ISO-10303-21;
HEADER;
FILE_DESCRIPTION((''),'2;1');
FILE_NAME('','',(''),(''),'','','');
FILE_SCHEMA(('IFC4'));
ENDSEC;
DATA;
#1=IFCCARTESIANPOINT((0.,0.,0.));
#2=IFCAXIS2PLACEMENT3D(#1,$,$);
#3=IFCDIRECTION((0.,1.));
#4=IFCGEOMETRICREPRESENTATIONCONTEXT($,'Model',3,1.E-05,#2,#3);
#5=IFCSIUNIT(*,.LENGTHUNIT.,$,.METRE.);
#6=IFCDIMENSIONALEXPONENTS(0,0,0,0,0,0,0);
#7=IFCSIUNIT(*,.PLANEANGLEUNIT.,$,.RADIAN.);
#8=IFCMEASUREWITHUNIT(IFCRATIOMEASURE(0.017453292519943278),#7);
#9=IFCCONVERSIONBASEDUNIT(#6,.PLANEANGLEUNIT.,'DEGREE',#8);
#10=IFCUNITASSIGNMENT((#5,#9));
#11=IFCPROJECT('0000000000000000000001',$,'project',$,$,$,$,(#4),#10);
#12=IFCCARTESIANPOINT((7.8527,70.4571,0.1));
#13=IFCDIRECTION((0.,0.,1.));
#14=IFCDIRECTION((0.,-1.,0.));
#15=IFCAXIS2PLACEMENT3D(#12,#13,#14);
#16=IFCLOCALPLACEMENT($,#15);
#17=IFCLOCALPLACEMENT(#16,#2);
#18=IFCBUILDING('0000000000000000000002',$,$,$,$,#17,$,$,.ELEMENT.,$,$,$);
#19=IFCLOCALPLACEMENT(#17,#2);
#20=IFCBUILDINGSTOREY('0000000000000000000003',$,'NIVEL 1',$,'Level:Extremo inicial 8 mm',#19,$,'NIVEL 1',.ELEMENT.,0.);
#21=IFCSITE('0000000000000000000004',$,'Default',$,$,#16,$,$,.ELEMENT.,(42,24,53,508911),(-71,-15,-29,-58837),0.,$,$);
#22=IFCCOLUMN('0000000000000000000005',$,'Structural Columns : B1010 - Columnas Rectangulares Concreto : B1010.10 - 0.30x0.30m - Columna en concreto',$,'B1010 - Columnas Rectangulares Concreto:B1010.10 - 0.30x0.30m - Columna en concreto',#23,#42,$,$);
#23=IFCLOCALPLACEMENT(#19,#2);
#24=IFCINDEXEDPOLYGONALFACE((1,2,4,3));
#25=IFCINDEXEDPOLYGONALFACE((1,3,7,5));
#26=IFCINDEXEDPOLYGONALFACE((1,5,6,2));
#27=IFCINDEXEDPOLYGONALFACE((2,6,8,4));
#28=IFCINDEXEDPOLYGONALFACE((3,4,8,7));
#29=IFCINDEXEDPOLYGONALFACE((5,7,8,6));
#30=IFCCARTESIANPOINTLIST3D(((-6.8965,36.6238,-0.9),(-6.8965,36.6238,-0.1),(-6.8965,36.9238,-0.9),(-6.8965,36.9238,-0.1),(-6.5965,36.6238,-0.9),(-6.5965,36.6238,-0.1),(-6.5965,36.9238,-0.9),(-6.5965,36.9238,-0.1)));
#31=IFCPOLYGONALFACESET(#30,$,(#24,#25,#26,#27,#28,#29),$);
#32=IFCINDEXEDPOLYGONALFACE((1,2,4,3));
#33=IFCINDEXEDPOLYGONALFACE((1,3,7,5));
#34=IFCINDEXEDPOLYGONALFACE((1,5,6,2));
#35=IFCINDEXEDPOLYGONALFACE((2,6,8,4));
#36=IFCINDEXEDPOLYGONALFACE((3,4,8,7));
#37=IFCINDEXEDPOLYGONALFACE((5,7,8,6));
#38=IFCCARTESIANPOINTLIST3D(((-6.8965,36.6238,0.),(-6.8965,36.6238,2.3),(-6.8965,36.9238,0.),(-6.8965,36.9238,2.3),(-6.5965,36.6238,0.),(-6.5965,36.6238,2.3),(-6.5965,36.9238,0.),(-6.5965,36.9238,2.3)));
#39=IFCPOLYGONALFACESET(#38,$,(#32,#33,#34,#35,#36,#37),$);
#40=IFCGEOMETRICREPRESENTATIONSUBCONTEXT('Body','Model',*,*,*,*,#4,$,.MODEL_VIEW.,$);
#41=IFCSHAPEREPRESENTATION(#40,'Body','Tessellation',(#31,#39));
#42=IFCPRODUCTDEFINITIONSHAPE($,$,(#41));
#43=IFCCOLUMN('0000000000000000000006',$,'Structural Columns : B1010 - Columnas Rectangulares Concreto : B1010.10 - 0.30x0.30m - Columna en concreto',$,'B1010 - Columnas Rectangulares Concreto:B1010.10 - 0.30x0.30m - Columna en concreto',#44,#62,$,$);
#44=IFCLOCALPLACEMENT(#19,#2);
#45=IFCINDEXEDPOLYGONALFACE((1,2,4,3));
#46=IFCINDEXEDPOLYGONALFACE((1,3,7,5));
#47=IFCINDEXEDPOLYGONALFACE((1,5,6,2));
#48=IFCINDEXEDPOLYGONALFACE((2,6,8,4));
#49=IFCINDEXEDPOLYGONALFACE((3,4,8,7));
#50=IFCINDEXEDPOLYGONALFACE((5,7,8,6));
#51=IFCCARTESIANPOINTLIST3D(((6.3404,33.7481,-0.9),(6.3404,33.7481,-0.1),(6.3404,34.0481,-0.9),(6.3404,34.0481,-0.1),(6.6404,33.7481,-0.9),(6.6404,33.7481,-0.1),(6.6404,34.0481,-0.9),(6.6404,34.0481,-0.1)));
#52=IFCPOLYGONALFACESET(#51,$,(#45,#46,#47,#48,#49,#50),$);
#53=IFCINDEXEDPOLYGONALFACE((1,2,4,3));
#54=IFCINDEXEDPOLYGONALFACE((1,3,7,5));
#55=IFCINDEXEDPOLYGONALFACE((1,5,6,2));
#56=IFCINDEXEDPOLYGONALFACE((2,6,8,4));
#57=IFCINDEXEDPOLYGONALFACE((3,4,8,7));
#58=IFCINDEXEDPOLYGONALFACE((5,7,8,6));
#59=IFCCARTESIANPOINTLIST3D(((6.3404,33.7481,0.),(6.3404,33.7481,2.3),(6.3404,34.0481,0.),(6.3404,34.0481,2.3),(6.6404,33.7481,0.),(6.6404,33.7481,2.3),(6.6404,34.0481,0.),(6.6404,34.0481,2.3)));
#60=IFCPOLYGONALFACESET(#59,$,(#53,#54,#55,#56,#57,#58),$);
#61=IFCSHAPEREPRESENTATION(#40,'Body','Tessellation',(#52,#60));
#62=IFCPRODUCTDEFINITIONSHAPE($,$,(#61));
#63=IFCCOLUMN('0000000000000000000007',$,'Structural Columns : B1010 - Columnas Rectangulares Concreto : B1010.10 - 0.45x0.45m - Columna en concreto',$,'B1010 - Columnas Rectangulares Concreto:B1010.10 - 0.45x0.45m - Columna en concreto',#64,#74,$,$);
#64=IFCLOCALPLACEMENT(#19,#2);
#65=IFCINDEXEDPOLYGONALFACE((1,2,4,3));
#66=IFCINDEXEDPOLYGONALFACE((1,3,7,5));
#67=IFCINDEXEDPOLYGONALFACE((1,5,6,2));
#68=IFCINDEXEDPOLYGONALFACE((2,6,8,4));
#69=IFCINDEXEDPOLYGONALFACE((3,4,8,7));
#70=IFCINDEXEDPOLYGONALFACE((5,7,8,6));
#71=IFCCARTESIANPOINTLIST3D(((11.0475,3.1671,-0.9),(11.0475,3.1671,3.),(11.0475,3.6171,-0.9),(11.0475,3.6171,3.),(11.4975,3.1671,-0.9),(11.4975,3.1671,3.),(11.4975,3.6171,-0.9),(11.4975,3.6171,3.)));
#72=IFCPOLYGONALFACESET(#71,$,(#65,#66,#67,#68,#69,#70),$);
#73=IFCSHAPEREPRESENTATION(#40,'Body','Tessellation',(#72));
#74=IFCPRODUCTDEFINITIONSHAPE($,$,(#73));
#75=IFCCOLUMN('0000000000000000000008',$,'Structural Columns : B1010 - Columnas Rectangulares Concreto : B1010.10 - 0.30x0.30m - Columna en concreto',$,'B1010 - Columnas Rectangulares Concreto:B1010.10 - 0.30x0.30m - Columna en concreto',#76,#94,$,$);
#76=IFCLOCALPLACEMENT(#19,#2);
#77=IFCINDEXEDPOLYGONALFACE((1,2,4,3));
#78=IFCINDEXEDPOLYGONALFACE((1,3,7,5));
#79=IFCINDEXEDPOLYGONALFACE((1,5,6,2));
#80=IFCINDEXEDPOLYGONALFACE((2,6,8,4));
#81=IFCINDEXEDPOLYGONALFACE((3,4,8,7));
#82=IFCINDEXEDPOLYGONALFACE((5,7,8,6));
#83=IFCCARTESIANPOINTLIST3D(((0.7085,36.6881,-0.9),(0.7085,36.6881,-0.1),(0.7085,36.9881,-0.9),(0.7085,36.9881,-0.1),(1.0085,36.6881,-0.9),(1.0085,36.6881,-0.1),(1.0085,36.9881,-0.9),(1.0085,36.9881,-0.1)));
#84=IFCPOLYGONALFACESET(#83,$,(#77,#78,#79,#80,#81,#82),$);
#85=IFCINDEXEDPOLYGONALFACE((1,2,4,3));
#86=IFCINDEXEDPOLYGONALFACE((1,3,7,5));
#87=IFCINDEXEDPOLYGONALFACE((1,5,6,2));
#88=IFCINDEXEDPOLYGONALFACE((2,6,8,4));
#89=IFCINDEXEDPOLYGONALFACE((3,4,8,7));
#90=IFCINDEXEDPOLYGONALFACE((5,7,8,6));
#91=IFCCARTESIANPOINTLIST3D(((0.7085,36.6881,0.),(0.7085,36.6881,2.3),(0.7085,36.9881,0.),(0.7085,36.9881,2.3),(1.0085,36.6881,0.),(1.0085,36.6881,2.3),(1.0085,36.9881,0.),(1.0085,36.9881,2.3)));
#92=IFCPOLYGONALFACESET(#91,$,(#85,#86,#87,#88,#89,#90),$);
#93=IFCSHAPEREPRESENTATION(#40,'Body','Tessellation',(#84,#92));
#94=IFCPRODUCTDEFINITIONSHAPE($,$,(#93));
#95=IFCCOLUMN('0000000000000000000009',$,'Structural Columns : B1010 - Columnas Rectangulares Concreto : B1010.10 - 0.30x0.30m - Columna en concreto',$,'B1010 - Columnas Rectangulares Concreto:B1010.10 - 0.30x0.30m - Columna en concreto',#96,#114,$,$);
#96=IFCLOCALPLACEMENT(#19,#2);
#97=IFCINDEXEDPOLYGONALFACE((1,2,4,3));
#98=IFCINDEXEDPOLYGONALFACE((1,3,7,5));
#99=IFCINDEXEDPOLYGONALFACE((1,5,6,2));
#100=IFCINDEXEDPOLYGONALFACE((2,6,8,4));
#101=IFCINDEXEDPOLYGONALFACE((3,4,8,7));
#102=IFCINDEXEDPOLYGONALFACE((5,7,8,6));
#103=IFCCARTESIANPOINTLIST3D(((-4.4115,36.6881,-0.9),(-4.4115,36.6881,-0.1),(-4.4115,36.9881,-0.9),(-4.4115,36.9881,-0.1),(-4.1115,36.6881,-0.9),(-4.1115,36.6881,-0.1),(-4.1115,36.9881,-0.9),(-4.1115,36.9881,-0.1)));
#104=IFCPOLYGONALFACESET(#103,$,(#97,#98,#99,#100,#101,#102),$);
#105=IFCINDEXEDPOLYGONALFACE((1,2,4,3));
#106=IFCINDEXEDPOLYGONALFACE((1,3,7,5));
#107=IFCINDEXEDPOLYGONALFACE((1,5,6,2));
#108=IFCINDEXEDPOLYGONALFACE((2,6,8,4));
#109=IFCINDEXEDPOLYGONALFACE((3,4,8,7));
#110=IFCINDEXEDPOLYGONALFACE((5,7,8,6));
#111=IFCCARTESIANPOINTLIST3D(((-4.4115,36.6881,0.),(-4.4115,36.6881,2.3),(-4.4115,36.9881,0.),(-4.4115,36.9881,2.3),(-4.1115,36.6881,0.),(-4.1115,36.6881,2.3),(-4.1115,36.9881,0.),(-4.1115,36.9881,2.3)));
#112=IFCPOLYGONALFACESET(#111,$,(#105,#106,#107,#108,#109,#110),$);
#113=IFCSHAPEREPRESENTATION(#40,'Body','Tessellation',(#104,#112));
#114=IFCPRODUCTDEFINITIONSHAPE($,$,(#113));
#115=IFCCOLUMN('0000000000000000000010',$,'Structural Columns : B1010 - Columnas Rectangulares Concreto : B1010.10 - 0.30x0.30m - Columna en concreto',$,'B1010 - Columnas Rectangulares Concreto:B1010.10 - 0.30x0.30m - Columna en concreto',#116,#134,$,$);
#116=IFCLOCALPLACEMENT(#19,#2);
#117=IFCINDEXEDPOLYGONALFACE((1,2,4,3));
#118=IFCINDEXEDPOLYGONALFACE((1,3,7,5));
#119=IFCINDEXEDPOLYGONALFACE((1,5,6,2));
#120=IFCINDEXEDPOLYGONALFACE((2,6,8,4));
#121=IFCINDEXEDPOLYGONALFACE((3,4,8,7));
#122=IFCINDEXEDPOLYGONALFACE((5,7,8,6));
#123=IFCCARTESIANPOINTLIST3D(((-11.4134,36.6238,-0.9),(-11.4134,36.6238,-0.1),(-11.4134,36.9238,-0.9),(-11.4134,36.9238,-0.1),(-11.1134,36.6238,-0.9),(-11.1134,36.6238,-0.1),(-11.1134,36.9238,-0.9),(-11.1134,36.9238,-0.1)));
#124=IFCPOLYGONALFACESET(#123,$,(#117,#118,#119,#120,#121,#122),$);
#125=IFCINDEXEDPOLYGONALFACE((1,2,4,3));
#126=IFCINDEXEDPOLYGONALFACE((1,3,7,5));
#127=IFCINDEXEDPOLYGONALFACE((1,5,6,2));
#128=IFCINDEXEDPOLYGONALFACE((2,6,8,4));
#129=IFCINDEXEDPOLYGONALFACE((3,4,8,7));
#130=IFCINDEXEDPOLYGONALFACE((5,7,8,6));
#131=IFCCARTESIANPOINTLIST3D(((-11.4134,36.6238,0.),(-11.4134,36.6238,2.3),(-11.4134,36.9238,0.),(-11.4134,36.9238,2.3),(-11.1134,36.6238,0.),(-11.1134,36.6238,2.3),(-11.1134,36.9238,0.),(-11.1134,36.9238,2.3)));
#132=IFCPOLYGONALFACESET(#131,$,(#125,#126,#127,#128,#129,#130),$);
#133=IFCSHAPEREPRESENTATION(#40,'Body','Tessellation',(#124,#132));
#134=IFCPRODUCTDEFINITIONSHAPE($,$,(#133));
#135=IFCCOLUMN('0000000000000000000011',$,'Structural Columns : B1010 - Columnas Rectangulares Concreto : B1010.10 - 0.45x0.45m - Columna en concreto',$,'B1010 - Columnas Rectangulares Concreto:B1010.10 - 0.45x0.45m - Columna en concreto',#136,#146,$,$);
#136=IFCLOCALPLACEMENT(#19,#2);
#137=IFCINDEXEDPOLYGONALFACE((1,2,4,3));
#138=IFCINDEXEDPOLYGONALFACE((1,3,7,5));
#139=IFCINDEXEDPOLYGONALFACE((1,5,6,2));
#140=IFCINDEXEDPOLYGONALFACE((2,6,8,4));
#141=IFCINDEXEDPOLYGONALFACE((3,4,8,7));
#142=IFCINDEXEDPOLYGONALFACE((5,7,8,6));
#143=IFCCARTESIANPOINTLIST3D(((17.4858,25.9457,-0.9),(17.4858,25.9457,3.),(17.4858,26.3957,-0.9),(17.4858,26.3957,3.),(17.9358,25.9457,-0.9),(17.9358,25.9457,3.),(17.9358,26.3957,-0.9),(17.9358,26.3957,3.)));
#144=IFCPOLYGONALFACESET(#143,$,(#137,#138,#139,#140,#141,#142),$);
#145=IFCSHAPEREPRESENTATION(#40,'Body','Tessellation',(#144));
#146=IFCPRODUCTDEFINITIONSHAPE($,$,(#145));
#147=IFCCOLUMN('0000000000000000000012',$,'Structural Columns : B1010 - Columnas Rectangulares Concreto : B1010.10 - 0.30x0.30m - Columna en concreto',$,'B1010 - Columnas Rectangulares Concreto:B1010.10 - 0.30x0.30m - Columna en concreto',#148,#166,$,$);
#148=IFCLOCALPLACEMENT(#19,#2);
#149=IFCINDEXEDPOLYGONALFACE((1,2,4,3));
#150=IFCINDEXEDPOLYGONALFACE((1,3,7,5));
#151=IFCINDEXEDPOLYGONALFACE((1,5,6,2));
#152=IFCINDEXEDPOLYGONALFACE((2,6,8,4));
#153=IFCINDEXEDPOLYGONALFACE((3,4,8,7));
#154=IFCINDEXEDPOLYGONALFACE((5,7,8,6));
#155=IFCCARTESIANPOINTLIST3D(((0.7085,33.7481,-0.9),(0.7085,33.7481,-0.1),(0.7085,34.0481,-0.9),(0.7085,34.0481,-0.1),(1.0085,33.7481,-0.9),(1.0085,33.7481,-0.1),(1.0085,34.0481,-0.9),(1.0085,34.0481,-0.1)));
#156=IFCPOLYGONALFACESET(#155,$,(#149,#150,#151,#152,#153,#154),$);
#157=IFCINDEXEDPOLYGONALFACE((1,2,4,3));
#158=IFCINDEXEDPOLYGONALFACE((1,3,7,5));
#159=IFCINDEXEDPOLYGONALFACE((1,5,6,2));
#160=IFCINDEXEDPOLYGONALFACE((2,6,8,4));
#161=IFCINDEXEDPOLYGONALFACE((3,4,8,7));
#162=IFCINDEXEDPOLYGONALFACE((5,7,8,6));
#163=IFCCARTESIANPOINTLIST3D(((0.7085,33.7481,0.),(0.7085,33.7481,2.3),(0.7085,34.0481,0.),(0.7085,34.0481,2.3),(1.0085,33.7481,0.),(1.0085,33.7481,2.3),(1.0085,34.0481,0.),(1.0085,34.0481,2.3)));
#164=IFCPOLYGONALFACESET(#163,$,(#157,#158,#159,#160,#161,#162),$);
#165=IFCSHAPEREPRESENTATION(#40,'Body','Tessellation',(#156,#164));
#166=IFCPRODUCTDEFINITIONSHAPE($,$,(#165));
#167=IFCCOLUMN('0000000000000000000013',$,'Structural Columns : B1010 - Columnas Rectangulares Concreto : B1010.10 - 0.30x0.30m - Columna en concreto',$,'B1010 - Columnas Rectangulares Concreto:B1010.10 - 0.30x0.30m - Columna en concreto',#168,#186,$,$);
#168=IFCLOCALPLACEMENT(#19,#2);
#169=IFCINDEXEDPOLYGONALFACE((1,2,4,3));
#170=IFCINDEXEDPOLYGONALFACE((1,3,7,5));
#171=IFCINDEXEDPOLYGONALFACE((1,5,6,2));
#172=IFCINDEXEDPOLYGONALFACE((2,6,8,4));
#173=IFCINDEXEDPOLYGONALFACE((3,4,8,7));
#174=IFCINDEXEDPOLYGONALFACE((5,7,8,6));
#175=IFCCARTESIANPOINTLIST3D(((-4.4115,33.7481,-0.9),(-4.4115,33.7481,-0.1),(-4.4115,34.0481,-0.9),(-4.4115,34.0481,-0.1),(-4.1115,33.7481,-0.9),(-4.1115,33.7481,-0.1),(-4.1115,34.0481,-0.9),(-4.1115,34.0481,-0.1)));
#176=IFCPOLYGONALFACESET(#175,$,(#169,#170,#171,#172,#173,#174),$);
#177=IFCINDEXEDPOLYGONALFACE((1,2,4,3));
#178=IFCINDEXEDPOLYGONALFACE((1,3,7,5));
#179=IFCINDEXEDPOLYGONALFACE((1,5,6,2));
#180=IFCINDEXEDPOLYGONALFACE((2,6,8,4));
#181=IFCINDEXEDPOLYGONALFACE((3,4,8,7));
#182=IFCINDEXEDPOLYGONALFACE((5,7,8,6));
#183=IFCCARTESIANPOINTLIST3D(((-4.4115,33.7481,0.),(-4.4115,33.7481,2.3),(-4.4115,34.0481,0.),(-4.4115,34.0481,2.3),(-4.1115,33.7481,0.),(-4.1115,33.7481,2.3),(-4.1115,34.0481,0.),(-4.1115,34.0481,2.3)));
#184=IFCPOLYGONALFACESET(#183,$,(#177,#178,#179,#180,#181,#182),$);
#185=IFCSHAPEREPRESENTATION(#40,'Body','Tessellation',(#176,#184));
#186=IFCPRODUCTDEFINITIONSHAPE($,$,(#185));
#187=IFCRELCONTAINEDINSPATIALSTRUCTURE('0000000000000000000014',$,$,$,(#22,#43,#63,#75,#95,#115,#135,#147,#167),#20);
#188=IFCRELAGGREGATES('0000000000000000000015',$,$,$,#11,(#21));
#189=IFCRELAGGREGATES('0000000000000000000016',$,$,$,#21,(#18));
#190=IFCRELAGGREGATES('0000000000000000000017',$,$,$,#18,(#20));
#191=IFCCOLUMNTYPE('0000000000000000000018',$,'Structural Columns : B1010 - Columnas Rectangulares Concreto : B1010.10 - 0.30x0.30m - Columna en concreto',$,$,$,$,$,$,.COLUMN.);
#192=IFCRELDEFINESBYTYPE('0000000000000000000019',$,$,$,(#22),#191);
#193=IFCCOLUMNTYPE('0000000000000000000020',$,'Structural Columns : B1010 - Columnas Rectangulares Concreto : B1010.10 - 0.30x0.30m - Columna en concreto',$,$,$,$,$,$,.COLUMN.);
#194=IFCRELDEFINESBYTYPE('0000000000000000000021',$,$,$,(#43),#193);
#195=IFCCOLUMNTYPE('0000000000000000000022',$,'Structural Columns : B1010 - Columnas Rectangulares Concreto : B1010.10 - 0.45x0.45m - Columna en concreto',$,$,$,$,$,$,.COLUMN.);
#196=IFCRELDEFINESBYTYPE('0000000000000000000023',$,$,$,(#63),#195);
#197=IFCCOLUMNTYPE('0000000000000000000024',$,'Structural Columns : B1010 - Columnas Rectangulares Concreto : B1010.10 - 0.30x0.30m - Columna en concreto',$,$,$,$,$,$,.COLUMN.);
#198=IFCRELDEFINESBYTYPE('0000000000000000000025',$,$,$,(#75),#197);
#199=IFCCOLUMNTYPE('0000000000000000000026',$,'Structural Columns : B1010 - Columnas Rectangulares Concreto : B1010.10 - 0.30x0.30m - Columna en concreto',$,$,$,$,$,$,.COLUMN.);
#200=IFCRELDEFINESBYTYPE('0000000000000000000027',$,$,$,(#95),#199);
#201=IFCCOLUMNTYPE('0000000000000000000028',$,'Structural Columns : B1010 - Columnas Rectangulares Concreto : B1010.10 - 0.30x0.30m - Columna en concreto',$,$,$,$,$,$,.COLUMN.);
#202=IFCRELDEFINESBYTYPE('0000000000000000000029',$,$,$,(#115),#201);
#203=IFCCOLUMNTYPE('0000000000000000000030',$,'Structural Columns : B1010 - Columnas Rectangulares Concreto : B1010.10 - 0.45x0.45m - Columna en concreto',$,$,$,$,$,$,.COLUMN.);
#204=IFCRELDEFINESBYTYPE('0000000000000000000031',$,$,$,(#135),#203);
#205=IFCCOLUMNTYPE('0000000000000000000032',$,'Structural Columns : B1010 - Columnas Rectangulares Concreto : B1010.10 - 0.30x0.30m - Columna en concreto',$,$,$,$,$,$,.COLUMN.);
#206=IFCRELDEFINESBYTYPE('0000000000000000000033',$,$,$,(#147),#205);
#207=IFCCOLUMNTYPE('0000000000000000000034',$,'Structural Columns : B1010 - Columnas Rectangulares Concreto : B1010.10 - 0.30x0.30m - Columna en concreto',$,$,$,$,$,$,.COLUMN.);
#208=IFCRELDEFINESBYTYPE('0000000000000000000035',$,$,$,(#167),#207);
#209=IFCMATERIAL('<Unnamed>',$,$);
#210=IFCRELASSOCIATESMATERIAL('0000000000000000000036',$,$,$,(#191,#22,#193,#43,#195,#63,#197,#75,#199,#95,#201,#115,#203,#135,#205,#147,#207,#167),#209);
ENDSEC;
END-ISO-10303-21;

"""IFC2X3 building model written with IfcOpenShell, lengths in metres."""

from ifc_helpers import new_model, entity, si_unit, converted_unit, direction, frame, frame_2d, origin, origin_2d_with_axis, place, context, subcontext, project, spatial, rectangle, extrude, source, transform, mapped, material, type_object, type_shapes, element, save


model = new_model("IFC2X3")

# Units and contexts
model_context = context("Model", 3, precision=1e-05, world=origin(), true_north=direction((0.0, 1.0)))
body_context = subcontext(model_context, "Body", "Model", "MODEL_VIEW")
ifc_project = project(units=[si_unit("LENGTHUNIT", "METRE"), converted_unit("PLANEANGLEUNIT", "DEGREE", entity("IfcRatioMeasure", 0.017453292519943278), si_unit("PLANEANGLEUNIT", "RADIAN"), dimensions=[0, 0, 0, 0, 0, 0, 0])], contexts=[model_context])

# Site, building, storey
site_placement = place(None, frame((7.8527, 70.4571, 0.1), z_axis=(0.0, 0.0, 1.0), x_axis=(0.0, -1.0, 0.0)))
site = spatial("IfcSite", under=ifc_project, at=site_placement, Name="Default", CompositionType="ELEMENT", RefLatitude=(42, 24, 53, 508911), RefLongitude=(-71, -15, -29, -58837), RefElevation=0.0)
building_placement = place(site_placement, origin())
building = spatial("IfcBuilding", under=site, at=building_placement, CompositionType="ELEMENT")
storey_placement = place(building_placement, origin())
storey = spatial("IfcBuildingStorey", under=building, at=storey_placement, Name="NIVEL 1", ObjectType="Level:Extremo inicial 8 mm", LongName="NIVEL 1", CompositionType="ELEMENT", Elevation=0.0)

# Columns
ifc_material_1 = material(Name="<Unnamed>")
column_type_1 = type_object("IfcColumnType", Name="Structural Columns : B1010 - Columnas Rectangulares Concreto : B1010.10 - 0.30x0.30m - Columna en concreto", PredefinedType="COLUMN", material=ifc_material_1)
shared_shape_1 = source(origin(), body_context, "Body", "SweptSolid", [
    extrude(rectangle(XDim=0.3, YDim=0.3, at=frame_2d((0.0, 0.0), x_axis=(1.0, 0.0))), frame((-6.7465, 36.7738, -0.9), z_axis=(0.0, 0.0, 1.0), x_axis=(0.0, -1.0, 0.0)), (0.0, 0.0, 1.0), 0.8),
    extrude(rectangle(XDim=0.3, YDim=0.3, at=frame_2d((0.0, 0.0), x_axis=(1.0, 0.0))), frame((-6.7465, 36.7738, 0.0), z_axis=(0.0, 0.0, 1.0), x_axis=(0.0, -1.0, 0.0)), (0.0, 0.0, 1.0), 2.3),
])
type_shapes(column_type_1, [shared_shape_1])
column_1_placement = place(storey_placement, origin())
element("IfcColumn", 1, at=column_1_placement, inside=storey, type_object=column_type_1, material=ifc_material_1, Name="Structural Columns : B1010 - Columnas Rectangulares Concreto : B1010.10 - 0.30x0.30m - Columna en concreto", ObjectType="B1010 - Columnas Rectangulares Concreto:B1010.10 - 0.30x0.30m - Columna en concreto", context=body_context, shape_type="MappedRepresentation", body=[
    mapped(shared_shape_1, transform((0.0, 0.0, 0.0), scale=1.0)),
])
column_type_2 = type_object("IfcColumnType", Name="Structural Columns : B1010 - Columnas Rectangulares Concreto : B1010.10 - 0.30x0.30m - Columna en concreto", PredefinedType="COLUMN", material=ifc_material_1)
shared_shape_2 = source(origin(), body_context, "Body", "SweptSolid", [
    extrude(rectangle(XDim=0.3, YDim=0.3, at=frame_2d((0.0, 0.0), x_axis=(1.0, 0.0))), frame((6.4904, 33.8981, -0.9), z_axis=(0.0, 0.0, 1.0), x_axis=(0.0, -1.0, 0.0)), (0.0, 0.0, 1.0), 0.8),
    extrude(rectangle(XDim=0.3, YDim=0.3, at=frame_2d((0.0, 0.0), x_axis=(1.0, 0.0))), frame((6.4904, 33.8981, 0.0), z_axis=(0.0, 0.0, 1.0), x_axis=(0.0, -1.0, 0.0)), (0.0, 0.0, 1.0), 2.3),
])
type_shapes(column_type_2, [shared_shape_2])
column_2_placement = place(storey_placement, origin())
element("IfcColumn", 2, at=column_2_placement, inside=storey, type_object=column_type_2, material=ifc_material_1, Name="Structural Columns : B1010 - Columnas Rectangulares Concreto : B1010.10 - 0.30x0.30m - Columna en concreto", ObjectType="B1010 - Columnas Rectangulares Concreto:B1010.10 - 0.30x0.30m - Columna en concreto", context=body_context, shape_type="MappedRepresentation", body=[
    mapped(shared_shape_2, transform((0.0, 0.0, 0.0), scale=1.0)),
])
column_type_3 = type_object("IfcColumnType", Name="Structural Columns : B1010 - Columnas Rectangulares Concreto : B1010.10 - 0.45x0.45m - Columna en concreto", PredefinedType="COLUMN", material=ifc_material_1)
shared_shape_3 = source(origin(), body_context, "Body", "SweptSolid", [
    extrude(rectangle(XDim=0.45, YDim=0.45, at=frame_2d((0.0, 0.0), x_axis=(1.0, 0.0))), frame((11.2725, 3.3921, -0.9), z_axis=(0.0, 0.0, 1.0), x_axis=(0.0, -1.0, 0.0)), (0.0, 0.0, 1.0), 3.9),
])
type_shapes(column_type_3, [shared_shape_3])
column_3_placement = place(storey_placement, origin())
element("IfcColumn", 3, at=column_3_placement, inside=storey, type_object=column_type_3, material=ifc_material_1, Name="Structural Columns : B1010 - Columnas Rectangulares Concreto : B1010.10 - 0.45x0.45m - Columna en concreto", ObjectType="B1010 - Columnas Rectangulares Concreto:B1010.10 - 0.45x0.45m - Columna en concreto", context=body_context, shape_type="MappedRepresentation", body=[
    mapped(shared_shape_3, transform((0.0, 0.0, 0.0), scale=1.0)),
])
column_type_4 = type_object("IfcColumnType", Name="Structural Columns : B1010 - Columnas Rectangulares Concreto : B1010.10 - 0.30x0.30m - Columna en concreto", PredefinedType="COLUMN", material=ifc_material_1)
shared_shape_4 = source(origin(), body_context, "Body", "SweptSolid", [
    extrude(rectangle(XDim=0.3, YDim=0.3, at=origin_2d_with_axis()), frame((0.8585, 36.8381, -0.9), z_axis=(0.0, 0.0, 1.0), x_axis=(0.0, -1.0, 0.0)), (0.0, 0.0, 1.0), 0.8),
    extrude(rectangle(XDim=0.3, YDim=0.3, at=origin_2d_with_axis()), frame((0.8585, 36.8381, 0.0), z_axis=(0.0, 0.0, 1.0), x_axis=(0.0, -1.0, 0.0)), (0.0, 0.0, 1.0), 2.3),
])
type_shapes(column_type_4, [shared_shape_4])
column_4_placement = place(storey_placement, origin())
element("IfcColumn", 4, at=column_4_placement, inside=storey, type_object=column_type_4, material=ifc_material_1, Name="Structural Columns : B1010 - Columnas Rectangulares Concreto : B1010.10 - 0.30x0.30m - Columna en concreto", ObjectType="B1010 - Columnas Rectangulares Concreto:B1010.10 - 0.30x0.30m - Columna en concreto", context=body_context, shape_type="MappedRepresentation", body=[
    mapped(shared_shape_4, transform((0.0, 0.0, 0.0), scale=1.0)),
])
column_type_5 = type_object("IfcColumnType", Name="Structural Columns : B1010 - Columnas Rectangulares Concreto : B1010.10 - 0.30x0.30m - Columna en concreto", PredefinedType="COLUMN", material=ifc_material_1)
shared_shape_5 = source(origin(), body_context, "Body", "SweptSolid", [
    extrude(rectangle(XDim=0.3, YDim=0.3, at=origin_2d_with_axis()), frame((-4.2615, 36.8381, -0.9), z_axis=(0.0, 0.0, 1.0), x_axis=(0.0, -1.0, 0.0)), (0.0, 0.0, 1.0), 0.8),
    extrude(rectangle(XDim=0.3, YDim=0.3, at=origin_2d_with_axis()), frame((-4.2615, 36.8381, 0.0), z_axis=(0.0, 0.0, 1.0), x_axis=(0.0, -1.0, 0.0)), (0.0, 0.0, 1.0), 2.3),
])
type_shapes(column_type_5, [shared_shape_5])
column_5_placement = place(storey_placement, origin())
element("IfcColumn", 5, at=column_5_placement, inside=storey, type_object=column_type_5, material=ifc_material_1, Name="Structural Columns : B1010 - Columnas Rectangulares Concreto : B1010.10 - 0.30x0.30m - Columna en concreto", ObjectType="B1010 - Columnas Rectangulares Concreto:B1010.10 - 0.30x0.30m - Columna en concreto", context=body_context, shape_type="MappedRepresentation", body=[
    mapped(shared_shape_5, transform((0.0, 0.0, 0.0), scale=1.0)),
])
column_type_6 = type_object("IfcColumnType", Name="Structural Columns : B1010 - Columnas Rectangulares Concreto : B1010.10 - 0.30x0.30m - Columna en concreto", PredefinedType="COLUMN", material=ifc_material_1)
shared_shape_6 = source(origin(), body_context, "Body", "SweptSolid", [
    extrude(rectangle(XDim=0.3, YDim=0.3, at=origin_2d_with_axis()), frame((-11.2634, 36.7738, -0.9), z_axis=(0.0, 0.0, 1.0), x_axis=(0.0, -1.0, 0.0)), (0.0, 0.0, 1.0), 0.8),
    extrude(rectangle(XDim=0.3, YDim=0.3, at=origin_2d_with_axis()), frame((-11.2634, 36.7738, 0.0), z_axis=(0.0, 0.0, 1.0), x_axis=(0.0, -1.0, 0.0)), (0.0, 0.0, 1.0), 2.3),
])
type_shapes(column_type_6, [shared_shape_6])
column_6_placement = place(storey_placement, origin())
element("IfcColumn", 6, at=column_6_placement, inside=storey, type_object=column_type_6, material=ifc_material_1, Name="Structural Columns : B1010 - Columnas Rectangulares Concreto : B1010.10 - 0.30x0.30m - Columna en concreto", ObjectType="B1010 - Columnas Rectangulares Concreto:B1010.10 - 0.30x0.30m - Columna en concreto", context=body_context, shape_type="MappedRepresentation", body=[
    mapped(shared_shape_6, transform((0.0, 0.0, 0.0), scale=1.0)),
])
column_type_7 = type_object("IfcColumnType", Name="Structural Columns : B1010 - Columnas Rectangulares Concreto : B1010.10 - 0.45x0.45m - Columna en concreto", PredefinedType="COLUMN", material=ifc_material_1)
shared_shape_7 = source(origin(), body_context, "Body", "SweptSolid", [
    extrude(rectangle(XDim=0.45, YDim=0.45, at=origin_2d_with_axis()), frame((17.7108, 26.1707, -0.9), z_axis=(0.0, 0.0, 1.0), x_axis=(0.0, -1.0, 0.0)), (0.0, 0.0, 1.0), 3.9),
])
type_shapes(column_type_7, [shared_shape_7])
column_7_placement = place(storey_placement, origin())
element("IfcColumn", 7, at=column_7_placement, inside=storey, type_object=column_type_7, material=ifc_material_1, Name="Structural Columns : B1010 - Columnas Rectangulares Concreto : B1010.10 - 0.45x0.45m - Columna en concreto", ObjectType="B1010 - Columnas Rectangulares Concreto:B1010.10 - 0.45x0.45m - Columna en concreto", context=body_context, shape_type="MappedRepresentation", body=[
    mapped(shared_shape_7, transform((0.0, 0.0, 0.0), scale=1.0)),
])
column_type_8 = type_object("IfcColumnType", Name="Structural Columns : B1010 - Columnas Rectangulares Concreto : B1010.10 - 0.30x0.30m - Columna en concreto", PredefinedType="COLUMN", material=ifc_material_1)
shared_shape_8 = source(origin(), body_context, "Body", "SweptSolid", [
    extrude(rectangle(XDim=0.3, YDim=0.3, at=origin_2d_with_axis()), frame((0.8585, 33.8981, -0.9), z_axis=(0.0, 0.0, 1.0), x_axis=(0.0, -1.0, 0.0)), (0.0, 0.0, 1.0), 0.8),
    extrude(rectangle(XDim=0.3, YDim=0.3, at=origin_2d_with_axis()), frame((0.8585, 33.8981, 0.0), z_axis=(0.0, 0.0, 1.0), x_axis=(0.0, -1.0, 0.0)), (0.0, 0.0, 1.0), 2.3),
])
type_shapes(column_type_8, [shared_shape_8])
column_8_placement = place(storey_placement, origin())
element("IfcColumn", 8, at=column_8_placement, inside=storey, type_object=column_type_8, material=ifc_material_1, Name="Structural Columns : B1010 - Columnas Rectangulares Concreto : B1010.10 - 0.30x0.30m - Columna en concreto", ObjectType="B1010 - Columnas Rectangulares Concreto:B1010.10 - 0.30x0.30m - Columna en concreto", context=body_context, shape_type="MappedRepresentation", body=[
    mapped(shared_shape_8, transform((0.0, 0.0, 0.0), scale=1.0)),
])
column_type_9 = type_object("IfcColumnType", Name="Structural Columns : B1010 - Columnas Rectangulares Concreto : B1010.10 - 0.30x0.30m - Columna en concreto", PredefinedType="COLUMN", material=ifc_material_1)
shared_shape_9 = source(origin(), body_context, "Body", "SweptSolid", [
    extrude(rectangle(XDim=0.3, YDim=0.3, at=origin_2d_with_axis()), frame((-4.2615, 33.8981, -0.9), z_axis=(0.0, 0.0, 1.0), x_axis=(0.0, -1.0, 0.0)), (0.0, 0.0, 1.0), 0.8),
    extrude(rectangle(XDim=0.3, YDim=0.3, at=origin_2d_with_axis()), frame((-4.2615, 33.8981, 0.0), z_axis=(0.0, 0.0, 1.0), x_axis=(0.0, -1.0, 0.0)), (0.0, 0.0, 1.0), 2.3),
])
type_shapes(column_type_9, [shared_shape_9])
column_9_placement = place(storey_placement, origin())
element("IfcColumn", 9, at=column_9_placement, inside=storey, type_object=column_type_9, material=ifc_material_1, Name="Structural Columns : B1010 - Columnas Rectangulares Concreto : B1010.10 - 0.30x0.30m - Columna en concreto", ObjectType="B1010 - Columnas Rectangulares Concreto:B1010.10 - 0.30x0.30m - Columna en concreto", context=body_context, shape_type="MappedRepresentation", body=[
    mapped(shared_shape_9, transform((0.0, 0.0, 0.0), scale=1.0)),
])

save(model, "model.ifc")
